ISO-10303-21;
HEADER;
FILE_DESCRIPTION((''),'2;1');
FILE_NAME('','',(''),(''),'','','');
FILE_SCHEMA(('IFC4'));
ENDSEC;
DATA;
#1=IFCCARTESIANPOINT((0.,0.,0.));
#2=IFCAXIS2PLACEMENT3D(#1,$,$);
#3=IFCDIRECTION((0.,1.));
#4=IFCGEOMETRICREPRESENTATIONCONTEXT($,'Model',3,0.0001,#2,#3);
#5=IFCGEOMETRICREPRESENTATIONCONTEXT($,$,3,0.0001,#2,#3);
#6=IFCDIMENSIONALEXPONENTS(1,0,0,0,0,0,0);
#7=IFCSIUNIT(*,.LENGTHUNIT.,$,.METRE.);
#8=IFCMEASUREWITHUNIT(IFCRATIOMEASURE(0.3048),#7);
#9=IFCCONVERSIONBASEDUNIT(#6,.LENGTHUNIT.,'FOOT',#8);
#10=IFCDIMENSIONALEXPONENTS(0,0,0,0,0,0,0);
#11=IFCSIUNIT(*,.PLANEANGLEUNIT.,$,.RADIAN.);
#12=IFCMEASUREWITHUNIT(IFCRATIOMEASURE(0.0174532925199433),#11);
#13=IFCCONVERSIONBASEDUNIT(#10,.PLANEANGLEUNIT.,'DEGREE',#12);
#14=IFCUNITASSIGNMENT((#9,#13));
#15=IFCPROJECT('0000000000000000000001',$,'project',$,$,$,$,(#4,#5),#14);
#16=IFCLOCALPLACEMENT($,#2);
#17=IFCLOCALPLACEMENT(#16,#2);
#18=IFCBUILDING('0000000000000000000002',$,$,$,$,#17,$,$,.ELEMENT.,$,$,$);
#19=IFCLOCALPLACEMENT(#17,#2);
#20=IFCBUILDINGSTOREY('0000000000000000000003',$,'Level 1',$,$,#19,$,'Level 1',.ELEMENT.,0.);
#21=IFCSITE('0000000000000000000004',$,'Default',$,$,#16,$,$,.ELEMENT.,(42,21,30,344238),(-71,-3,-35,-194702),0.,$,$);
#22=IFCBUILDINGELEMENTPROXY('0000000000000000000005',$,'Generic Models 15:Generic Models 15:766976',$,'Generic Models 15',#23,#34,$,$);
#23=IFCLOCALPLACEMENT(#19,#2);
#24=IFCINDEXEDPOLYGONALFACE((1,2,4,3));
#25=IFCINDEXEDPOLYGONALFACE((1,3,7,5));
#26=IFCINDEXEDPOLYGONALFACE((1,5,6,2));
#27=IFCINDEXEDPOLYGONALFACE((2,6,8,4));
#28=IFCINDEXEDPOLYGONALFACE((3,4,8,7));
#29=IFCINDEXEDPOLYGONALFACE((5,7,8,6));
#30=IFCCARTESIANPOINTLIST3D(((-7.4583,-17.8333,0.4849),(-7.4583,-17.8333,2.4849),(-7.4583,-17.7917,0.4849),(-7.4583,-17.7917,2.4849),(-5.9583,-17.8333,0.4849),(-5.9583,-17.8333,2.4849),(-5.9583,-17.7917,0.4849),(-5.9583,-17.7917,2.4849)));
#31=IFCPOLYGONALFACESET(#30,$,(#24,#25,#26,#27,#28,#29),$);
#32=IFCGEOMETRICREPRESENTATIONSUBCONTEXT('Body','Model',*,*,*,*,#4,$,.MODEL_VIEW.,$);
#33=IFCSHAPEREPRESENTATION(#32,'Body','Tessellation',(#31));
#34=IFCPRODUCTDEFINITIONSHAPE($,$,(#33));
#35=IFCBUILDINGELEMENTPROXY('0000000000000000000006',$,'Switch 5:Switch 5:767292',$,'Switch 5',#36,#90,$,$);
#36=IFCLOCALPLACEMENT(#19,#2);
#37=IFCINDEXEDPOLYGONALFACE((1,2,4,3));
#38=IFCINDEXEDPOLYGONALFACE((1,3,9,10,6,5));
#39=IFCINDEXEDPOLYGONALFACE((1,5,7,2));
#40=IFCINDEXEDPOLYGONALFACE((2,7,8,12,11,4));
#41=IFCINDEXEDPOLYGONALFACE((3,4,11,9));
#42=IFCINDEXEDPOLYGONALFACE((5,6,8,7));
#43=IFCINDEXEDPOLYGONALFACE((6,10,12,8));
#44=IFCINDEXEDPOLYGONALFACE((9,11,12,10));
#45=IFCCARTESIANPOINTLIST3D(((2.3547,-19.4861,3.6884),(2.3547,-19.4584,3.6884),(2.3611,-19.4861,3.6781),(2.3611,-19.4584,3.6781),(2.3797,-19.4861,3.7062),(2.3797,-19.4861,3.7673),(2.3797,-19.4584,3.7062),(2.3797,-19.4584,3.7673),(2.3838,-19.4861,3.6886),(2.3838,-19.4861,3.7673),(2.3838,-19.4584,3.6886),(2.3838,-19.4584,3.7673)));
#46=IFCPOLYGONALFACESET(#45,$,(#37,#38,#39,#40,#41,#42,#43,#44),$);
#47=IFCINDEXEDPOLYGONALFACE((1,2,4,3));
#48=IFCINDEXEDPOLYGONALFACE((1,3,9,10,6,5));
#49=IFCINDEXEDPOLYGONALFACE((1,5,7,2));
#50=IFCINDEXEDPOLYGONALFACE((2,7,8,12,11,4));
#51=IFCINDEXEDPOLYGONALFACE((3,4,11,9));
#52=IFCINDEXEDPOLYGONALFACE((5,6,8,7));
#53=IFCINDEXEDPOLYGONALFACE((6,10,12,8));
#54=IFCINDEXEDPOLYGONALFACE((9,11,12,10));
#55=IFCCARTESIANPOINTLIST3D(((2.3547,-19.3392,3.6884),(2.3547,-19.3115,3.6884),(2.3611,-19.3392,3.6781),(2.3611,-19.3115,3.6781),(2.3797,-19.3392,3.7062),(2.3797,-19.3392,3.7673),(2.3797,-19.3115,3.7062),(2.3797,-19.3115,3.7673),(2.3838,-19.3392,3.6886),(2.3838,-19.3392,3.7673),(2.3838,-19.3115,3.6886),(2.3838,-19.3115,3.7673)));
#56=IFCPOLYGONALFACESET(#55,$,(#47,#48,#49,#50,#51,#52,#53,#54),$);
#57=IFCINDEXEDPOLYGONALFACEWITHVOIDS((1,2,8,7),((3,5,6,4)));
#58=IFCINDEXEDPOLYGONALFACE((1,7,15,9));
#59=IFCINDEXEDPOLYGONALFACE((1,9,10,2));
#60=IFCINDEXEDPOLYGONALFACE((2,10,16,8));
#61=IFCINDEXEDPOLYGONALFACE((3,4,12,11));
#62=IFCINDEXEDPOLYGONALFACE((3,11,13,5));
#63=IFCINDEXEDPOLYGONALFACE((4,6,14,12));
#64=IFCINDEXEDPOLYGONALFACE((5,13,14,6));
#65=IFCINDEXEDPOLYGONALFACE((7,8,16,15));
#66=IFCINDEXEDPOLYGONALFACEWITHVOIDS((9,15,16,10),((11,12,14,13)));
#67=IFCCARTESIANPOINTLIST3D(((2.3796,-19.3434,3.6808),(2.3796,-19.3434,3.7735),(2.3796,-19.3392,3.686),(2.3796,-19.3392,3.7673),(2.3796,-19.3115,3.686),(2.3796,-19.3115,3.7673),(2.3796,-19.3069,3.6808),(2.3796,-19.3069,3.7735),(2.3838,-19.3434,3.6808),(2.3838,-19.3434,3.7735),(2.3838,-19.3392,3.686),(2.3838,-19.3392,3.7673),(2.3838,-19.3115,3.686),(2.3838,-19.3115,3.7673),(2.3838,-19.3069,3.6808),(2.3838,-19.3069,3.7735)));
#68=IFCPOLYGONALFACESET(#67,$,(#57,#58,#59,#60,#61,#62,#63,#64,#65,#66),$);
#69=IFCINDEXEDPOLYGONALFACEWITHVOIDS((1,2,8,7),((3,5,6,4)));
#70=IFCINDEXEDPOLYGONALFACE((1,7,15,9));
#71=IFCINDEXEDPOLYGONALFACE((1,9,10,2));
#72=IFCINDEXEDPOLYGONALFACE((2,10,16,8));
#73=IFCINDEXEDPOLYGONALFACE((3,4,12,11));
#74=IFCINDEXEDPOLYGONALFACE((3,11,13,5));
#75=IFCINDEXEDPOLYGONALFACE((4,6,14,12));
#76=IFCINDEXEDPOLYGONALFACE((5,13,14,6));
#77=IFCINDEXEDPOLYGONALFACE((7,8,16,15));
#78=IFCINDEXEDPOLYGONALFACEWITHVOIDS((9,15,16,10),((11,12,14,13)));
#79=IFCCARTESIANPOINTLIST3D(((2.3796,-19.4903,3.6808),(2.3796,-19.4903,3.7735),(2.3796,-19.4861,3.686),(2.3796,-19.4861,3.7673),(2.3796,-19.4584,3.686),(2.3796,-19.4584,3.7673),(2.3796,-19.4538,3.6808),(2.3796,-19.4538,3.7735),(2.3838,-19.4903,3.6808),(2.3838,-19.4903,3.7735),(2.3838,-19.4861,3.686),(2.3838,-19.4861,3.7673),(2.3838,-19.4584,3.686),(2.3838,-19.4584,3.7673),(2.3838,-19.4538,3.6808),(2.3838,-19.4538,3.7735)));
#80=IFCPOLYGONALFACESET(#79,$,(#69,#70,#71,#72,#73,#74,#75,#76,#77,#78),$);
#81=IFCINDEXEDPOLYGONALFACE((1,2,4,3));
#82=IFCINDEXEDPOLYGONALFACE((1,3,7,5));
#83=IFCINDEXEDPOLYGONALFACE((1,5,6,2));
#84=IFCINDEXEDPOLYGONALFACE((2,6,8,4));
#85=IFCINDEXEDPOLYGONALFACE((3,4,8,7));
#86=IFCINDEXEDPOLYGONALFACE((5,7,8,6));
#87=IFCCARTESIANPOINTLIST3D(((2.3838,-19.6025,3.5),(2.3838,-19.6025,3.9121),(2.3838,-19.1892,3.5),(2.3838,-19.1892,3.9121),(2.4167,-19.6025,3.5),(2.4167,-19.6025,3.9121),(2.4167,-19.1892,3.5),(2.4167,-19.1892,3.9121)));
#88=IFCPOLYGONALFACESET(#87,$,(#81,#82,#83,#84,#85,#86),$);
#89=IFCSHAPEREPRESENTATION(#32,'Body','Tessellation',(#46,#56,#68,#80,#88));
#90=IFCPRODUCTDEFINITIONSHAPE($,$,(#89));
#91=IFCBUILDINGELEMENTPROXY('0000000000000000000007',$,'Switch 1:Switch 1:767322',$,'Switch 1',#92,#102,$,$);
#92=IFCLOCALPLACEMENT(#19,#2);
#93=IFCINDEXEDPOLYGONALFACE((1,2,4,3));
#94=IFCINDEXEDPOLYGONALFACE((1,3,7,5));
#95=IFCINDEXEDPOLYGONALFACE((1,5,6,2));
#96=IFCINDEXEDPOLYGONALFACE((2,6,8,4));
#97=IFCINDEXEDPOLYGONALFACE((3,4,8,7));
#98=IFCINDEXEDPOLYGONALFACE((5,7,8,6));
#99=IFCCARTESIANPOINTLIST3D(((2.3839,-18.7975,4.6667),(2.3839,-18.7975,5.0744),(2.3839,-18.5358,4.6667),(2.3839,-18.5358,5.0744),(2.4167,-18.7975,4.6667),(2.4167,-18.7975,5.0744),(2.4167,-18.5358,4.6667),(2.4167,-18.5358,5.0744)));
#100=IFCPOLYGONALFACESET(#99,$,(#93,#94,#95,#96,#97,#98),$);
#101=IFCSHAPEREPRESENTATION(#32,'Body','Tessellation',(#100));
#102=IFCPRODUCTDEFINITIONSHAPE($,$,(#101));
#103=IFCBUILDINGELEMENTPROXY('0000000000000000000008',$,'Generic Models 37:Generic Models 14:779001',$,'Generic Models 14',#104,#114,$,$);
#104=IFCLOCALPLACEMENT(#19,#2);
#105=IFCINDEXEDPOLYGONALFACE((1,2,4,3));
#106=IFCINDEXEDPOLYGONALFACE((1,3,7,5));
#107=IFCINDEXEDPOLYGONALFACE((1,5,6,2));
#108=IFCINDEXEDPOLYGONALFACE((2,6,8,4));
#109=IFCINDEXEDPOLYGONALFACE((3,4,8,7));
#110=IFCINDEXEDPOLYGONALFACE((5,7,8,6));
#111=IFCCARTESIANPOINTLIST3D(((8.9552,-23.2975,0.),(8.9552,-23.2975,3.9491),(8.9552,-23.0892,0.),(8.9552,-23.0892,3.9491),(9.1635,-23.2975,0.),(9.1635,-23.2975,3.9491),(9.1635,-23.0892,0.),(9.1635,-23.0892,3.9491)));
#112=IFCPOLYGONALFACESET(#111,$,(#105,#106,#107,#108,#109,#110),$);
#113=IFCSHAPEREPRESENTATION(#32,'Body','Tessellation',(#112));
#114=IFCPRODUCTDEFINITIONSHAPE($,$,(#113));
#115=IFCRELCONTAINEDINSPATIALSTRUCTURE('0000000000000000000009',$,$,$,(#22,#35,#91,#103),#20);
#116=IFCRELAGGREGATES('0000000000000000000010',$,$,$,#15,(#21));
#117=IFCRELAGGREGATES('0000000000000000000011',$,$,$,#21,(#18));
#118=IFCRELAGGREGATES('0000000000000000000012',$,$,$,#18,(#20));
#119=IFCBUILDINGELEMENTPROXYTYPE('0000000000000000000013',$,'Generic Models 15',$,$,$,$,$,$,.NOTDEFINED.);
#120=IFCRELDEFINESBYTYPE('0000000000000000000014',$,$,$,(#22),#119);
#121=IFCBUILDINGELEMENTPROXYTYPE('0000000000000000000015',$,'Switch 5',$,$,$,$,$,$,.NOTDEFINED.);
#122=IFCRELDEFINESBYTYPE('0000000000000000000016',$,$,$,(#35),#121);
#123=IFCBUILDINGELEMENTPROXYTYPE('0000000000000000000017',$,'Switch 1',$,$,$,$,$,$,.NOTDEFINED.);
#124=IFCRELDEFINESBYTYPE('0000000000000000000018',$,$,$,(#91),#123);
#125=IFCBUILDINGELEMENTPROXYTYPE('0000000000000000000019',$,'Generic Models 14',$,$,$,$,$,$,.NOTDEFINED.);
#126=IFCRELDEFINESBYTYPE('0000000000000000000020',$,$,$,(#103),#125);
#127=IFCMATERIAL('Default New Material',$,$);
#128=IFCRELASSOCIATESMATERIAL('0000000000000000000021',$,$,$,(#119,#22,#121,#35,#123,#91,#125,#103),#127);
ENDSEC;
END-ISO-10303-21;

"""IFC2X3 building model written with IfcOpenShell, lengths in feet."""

from ifc_helpers import new_model, entity, si_unit, converted_unit, direction, frame, frame_2d, origin, origin_2d_with_axis, place, context, subcontext, project, spatial, polyline, rectangle, outline, extrude, source, transform, mapped, material, type_object, type_shapes, element, save


model = new_model("IFC2X3")

# Units and contexts
model_context = context("Model", 3, precision=0.0001, world=origin(), true_north=direction((0.0, 1.0)))
context_of_model = context(None, 3, precision=0.0001, world=origin(), true_north=direction((0.0, 1.0)))
body_context = subcontext(model_context, "Body", "Model", "MODEL_VIEW")
ifc_project = project(units=[converted_unit("LENGTHUNIT", "FOOT", entity("IfcRatioMeasure", 0.3048), si_unit("LENGTHUNIT", "METRE"), dimensions=[1, 0, 0, 0, 0, 0, 0]), converted_unit("PLANEANGLEUNIT", "DEGREE", entity("IfcRatioMeasure", 0.0174532925199433), si_unit("PLANEANGLEUNIT", "RADIAN"), dimensions=[0, 0, 0, 0, 0, 0, 0])], contexts=[model_context, context_of_model])

# Site, building, storey
site_placement = place(None, origin())
site = spatial("IfcSite", under=ifc_project, at=site_placement, Name="Default", CompositionType="ELEMENT", RefLatitude=(42, 21, 30, 344238), RefLongitude=(-71, -3, -35, -194702), RefElevation=0.0)
building_placement = place(site_placement, origin())
building = spatial("IfcBuilding", under=site, at=building_placement, CompositionType="ELEMENT")
storey_placement = place(building_placement, origin())
storey = spatial("IfcBuildingStorey", under=building, at=storey_placement, Name="Level 1", LongName="Level 1", CompositionType="ELEMENT", Elevation=0.0)

# Shared definitions
ifc_material = material(Name="Default New Material")

# Building element proxies
building_element_proxy_type_1 = type_object("IfcBuildingElementProxyType", Name="Generic Models 15", PredefinedType="NOTDEFINED", material=ifc_material)
shared_shape_1 = source(origin(), body_context, "Body", "SweptSolid", [
    extrude(rectangle(XDim=0.0417, YDim=1.5, at=frame_2d((0.0, 0.0), x_axis=(1.0, 0.0))), frame((0.75, 0.0208, 0.0), z_axis=(0.0, 0.0, 1.0), x_axis=(0.0, 1.0, 0.0)), (0.0, 0.0, 1.0), 2.0),
])
type_shapes(building_element_proxy_type_1, [shared_shape_1])
proxy_1_placement = place(storey_placement, frame((-7.4583, -17.8333, 0.4849)))
element("IfcBuildingElementProxy", 1, at=proxy_1_placement, inside=storey, type_object=building_element_proxy_type_1, material=ifc_material, Name="Generic Models 15:Generic Models 15:766976", ObjectType="Generic Models 15", context=body_context, shape_type="MappedRepresentation", body=[
    mapped(shared_shape_1, transform((0.0, 0.0, 0.0), scale=1.0)),
])
building_element_proxy_type_2 = type_object("IfcBuildingElementProxyType", Name="Switch 5", PredefinedType="NOTDEFINED", material=ifc_material)
shared_shape_2 = source(origin(), body_context, "Body", "SweptSolid", [
    extrude(outline(polyline([(-0.0275, -0.029), (-0.0025, -0.029), (0.0307, 0.0424), (0.027, 0.0441), (0.0012, -0.0114), (-0.0289, -0.017), (-0.0275, -0.029)])), frame((0.0626, -0.0429, 0.216), z_axis=(1.0, 0.0, 0.0), x_axis=(0.0, 0.906882, 0.421385)), (0.0, 0.0, 1.0), 0.0277),
    extrude(outline(polyline([(-0.0275, -0.029), (-0.0025, -0.029), (0.0307, 0.0424), (0.027, 0.0441), (0.0012, -0.0114), (-0.0289, -0.017), (-0.0275, -0.029)])), frame((-0.0843, -0.0429, 0.216), z_axis=(1.0, 0.0, 0.0), x_axis=(0.0, 0.906882, 0.421385)), (0.0, 0.0, 1.0), 0.0277),
    extrude(outline(polyline([(-0.0464, -0.0182), (0.0464, -0.0182), (0.0464, 0.0182), (-0.0464, 0.0182), (-0.0464, -0.0182)]), holes=[polyline([(-0.0402, -0.0141), (-0.0402, 0.0136), (0.0411, 0.0136), (0.0411, -0.0141), (-0.0402, -0.0141)])]), frame((-0.0707, -0.0371, 0.2271), z_axis=(0.0, 1.0, 0.0), x_axis=(0.0, 0.0, -1.0)), (0.0, 0.0, 1.0), 0.0042),
    extrude(outline(polyline([(-0.0464, -0.0182), (0.0464, -0.0182), (0.0464, 0.0182), (-0.0464, 0.0182), (-0.0464, -0.0182)]), holes=[polyline([(-0.0402, -0.0141), (-0.0402, 0.0136), (0.0411, 0.0136), (0.0411, -0.0141), (-0.0402, -0.0141)])]), frame((0.0762, -0.0371, 0.2271), z_axis=(0.0, 1.0, 0.0), x_axis=(0.0, 0.0, -1.0)), (0.0, 0.0, 1.0), 0.0042),
    extrude(rectangle(XDim=0.4134, YDim=0.0329, at=origin_2d_with_axis()), frame((0.0, -0.0164, 0.0)), (0.0, 0.0, 1.0), 0.4121),
])
type_shapes(building_element_proxy_type_2, [shared_shape_2])
proxy_2_placement = place(storey_placement, frame((2.4167, -19.3958, 3.5), z_axis=(0.0, 0.0, 1.0), x_axis=(0.0, -1.0, 0.0)))
element("IfcBuildingElementProxy", 2, at=proxy_2_placement, inside=storey, type_object=building_element_proxy_type_2, material=ifc_material, Name="Switch 5:Switch 5:767292", ObjectType="Switch 5", context=body_context, shape_type="MappedRepresentation", body=[
    mapped(shared_shape_2, transform((0.0, 0.0, 0.0), scale=1.0)),
])
building_element_proxy_type_3 = type_object("IfcBuildingElementProxyType", Name="Switch 1", PredefinedType="NOTDEFINED", material=ifc_material)
shared_shape_3 = source(origin(), body_context, "Body", "SweptSolid", [
    extrude(rectangle(XDim=0.2617, YDim=0.0328, at=origin_2d_with_axis()), frame((0.0, 0.0164, 0.0), z_axis=(0.0, 0.0, 1.0), x_axis=(-1.0, 0.0, 0.0)), (0.0, 0.0, 1.0), 0.4078),
])
type_shapes(building_element_proxy_type_3, [shared_shape_3])
proxy_3_placement = place(storey_placement, frame((2.3839, -18.6667, 4.6667), z_axis=(0.0, 0.0, 1.0), x_axis=(0.0, -1.0, 0.0)))
element("IfcBuildingElementProxy", 3, at=proxy_3_placement, inside=storey, type_object=building_element_proxy_type_3, material=ifc_material, Name="Switch 1:Switch 1:767322", ObjectType="Switch 1", context=body_context, shape_type="MappedRepresentation", body=[
    mapped(shared_shape_3, transform((0.0, 0.0, 0.0), scale=1.0)),
])
building_element_proxy_type_4 = type_object("IfcBuildingElementProxyType", Name="Generic Models 14", PredefinedType="NOTDEFINED", material=ifc_material)
shared_shape_4 = source(origin(), body_context, "Body", "SweptSolid", [
    extrude(rectangle(XDim=0.2083, YDim=0.2083, at=frame_2d((0.0, 0.0), x_axis=(1.0, 0.0))), frame((0.1042, 0.1042, 0.0), z_axis=(0.0, 0.0, 1.0), x_axis=(0.0, 1.0, 0.0)), (0.0, 0.0, 1.0), 3.9491),
])
type_shapes(building_element_proxy_type_4, [shared_shape_4])
proxy_4_placement = place(storey_placement, frame((8.9552, -23.2975, 0.0)))
element("IfcBuildingElementProxy", 4, at=proxy_4_placement, inside=storey, type_object=building_element_proxy_type_4, material=ifc_material, Name="Generic Models 37:Generic Models 14:779001", ObjectType="Generic Models 14", context=body_context, shape_type="MappedRepresentation", body=[
    mapped(shared_shape_4, transform((0.0, 0.0, 0.0), scale=1.0)),
])

save(model, "model.ifc")
